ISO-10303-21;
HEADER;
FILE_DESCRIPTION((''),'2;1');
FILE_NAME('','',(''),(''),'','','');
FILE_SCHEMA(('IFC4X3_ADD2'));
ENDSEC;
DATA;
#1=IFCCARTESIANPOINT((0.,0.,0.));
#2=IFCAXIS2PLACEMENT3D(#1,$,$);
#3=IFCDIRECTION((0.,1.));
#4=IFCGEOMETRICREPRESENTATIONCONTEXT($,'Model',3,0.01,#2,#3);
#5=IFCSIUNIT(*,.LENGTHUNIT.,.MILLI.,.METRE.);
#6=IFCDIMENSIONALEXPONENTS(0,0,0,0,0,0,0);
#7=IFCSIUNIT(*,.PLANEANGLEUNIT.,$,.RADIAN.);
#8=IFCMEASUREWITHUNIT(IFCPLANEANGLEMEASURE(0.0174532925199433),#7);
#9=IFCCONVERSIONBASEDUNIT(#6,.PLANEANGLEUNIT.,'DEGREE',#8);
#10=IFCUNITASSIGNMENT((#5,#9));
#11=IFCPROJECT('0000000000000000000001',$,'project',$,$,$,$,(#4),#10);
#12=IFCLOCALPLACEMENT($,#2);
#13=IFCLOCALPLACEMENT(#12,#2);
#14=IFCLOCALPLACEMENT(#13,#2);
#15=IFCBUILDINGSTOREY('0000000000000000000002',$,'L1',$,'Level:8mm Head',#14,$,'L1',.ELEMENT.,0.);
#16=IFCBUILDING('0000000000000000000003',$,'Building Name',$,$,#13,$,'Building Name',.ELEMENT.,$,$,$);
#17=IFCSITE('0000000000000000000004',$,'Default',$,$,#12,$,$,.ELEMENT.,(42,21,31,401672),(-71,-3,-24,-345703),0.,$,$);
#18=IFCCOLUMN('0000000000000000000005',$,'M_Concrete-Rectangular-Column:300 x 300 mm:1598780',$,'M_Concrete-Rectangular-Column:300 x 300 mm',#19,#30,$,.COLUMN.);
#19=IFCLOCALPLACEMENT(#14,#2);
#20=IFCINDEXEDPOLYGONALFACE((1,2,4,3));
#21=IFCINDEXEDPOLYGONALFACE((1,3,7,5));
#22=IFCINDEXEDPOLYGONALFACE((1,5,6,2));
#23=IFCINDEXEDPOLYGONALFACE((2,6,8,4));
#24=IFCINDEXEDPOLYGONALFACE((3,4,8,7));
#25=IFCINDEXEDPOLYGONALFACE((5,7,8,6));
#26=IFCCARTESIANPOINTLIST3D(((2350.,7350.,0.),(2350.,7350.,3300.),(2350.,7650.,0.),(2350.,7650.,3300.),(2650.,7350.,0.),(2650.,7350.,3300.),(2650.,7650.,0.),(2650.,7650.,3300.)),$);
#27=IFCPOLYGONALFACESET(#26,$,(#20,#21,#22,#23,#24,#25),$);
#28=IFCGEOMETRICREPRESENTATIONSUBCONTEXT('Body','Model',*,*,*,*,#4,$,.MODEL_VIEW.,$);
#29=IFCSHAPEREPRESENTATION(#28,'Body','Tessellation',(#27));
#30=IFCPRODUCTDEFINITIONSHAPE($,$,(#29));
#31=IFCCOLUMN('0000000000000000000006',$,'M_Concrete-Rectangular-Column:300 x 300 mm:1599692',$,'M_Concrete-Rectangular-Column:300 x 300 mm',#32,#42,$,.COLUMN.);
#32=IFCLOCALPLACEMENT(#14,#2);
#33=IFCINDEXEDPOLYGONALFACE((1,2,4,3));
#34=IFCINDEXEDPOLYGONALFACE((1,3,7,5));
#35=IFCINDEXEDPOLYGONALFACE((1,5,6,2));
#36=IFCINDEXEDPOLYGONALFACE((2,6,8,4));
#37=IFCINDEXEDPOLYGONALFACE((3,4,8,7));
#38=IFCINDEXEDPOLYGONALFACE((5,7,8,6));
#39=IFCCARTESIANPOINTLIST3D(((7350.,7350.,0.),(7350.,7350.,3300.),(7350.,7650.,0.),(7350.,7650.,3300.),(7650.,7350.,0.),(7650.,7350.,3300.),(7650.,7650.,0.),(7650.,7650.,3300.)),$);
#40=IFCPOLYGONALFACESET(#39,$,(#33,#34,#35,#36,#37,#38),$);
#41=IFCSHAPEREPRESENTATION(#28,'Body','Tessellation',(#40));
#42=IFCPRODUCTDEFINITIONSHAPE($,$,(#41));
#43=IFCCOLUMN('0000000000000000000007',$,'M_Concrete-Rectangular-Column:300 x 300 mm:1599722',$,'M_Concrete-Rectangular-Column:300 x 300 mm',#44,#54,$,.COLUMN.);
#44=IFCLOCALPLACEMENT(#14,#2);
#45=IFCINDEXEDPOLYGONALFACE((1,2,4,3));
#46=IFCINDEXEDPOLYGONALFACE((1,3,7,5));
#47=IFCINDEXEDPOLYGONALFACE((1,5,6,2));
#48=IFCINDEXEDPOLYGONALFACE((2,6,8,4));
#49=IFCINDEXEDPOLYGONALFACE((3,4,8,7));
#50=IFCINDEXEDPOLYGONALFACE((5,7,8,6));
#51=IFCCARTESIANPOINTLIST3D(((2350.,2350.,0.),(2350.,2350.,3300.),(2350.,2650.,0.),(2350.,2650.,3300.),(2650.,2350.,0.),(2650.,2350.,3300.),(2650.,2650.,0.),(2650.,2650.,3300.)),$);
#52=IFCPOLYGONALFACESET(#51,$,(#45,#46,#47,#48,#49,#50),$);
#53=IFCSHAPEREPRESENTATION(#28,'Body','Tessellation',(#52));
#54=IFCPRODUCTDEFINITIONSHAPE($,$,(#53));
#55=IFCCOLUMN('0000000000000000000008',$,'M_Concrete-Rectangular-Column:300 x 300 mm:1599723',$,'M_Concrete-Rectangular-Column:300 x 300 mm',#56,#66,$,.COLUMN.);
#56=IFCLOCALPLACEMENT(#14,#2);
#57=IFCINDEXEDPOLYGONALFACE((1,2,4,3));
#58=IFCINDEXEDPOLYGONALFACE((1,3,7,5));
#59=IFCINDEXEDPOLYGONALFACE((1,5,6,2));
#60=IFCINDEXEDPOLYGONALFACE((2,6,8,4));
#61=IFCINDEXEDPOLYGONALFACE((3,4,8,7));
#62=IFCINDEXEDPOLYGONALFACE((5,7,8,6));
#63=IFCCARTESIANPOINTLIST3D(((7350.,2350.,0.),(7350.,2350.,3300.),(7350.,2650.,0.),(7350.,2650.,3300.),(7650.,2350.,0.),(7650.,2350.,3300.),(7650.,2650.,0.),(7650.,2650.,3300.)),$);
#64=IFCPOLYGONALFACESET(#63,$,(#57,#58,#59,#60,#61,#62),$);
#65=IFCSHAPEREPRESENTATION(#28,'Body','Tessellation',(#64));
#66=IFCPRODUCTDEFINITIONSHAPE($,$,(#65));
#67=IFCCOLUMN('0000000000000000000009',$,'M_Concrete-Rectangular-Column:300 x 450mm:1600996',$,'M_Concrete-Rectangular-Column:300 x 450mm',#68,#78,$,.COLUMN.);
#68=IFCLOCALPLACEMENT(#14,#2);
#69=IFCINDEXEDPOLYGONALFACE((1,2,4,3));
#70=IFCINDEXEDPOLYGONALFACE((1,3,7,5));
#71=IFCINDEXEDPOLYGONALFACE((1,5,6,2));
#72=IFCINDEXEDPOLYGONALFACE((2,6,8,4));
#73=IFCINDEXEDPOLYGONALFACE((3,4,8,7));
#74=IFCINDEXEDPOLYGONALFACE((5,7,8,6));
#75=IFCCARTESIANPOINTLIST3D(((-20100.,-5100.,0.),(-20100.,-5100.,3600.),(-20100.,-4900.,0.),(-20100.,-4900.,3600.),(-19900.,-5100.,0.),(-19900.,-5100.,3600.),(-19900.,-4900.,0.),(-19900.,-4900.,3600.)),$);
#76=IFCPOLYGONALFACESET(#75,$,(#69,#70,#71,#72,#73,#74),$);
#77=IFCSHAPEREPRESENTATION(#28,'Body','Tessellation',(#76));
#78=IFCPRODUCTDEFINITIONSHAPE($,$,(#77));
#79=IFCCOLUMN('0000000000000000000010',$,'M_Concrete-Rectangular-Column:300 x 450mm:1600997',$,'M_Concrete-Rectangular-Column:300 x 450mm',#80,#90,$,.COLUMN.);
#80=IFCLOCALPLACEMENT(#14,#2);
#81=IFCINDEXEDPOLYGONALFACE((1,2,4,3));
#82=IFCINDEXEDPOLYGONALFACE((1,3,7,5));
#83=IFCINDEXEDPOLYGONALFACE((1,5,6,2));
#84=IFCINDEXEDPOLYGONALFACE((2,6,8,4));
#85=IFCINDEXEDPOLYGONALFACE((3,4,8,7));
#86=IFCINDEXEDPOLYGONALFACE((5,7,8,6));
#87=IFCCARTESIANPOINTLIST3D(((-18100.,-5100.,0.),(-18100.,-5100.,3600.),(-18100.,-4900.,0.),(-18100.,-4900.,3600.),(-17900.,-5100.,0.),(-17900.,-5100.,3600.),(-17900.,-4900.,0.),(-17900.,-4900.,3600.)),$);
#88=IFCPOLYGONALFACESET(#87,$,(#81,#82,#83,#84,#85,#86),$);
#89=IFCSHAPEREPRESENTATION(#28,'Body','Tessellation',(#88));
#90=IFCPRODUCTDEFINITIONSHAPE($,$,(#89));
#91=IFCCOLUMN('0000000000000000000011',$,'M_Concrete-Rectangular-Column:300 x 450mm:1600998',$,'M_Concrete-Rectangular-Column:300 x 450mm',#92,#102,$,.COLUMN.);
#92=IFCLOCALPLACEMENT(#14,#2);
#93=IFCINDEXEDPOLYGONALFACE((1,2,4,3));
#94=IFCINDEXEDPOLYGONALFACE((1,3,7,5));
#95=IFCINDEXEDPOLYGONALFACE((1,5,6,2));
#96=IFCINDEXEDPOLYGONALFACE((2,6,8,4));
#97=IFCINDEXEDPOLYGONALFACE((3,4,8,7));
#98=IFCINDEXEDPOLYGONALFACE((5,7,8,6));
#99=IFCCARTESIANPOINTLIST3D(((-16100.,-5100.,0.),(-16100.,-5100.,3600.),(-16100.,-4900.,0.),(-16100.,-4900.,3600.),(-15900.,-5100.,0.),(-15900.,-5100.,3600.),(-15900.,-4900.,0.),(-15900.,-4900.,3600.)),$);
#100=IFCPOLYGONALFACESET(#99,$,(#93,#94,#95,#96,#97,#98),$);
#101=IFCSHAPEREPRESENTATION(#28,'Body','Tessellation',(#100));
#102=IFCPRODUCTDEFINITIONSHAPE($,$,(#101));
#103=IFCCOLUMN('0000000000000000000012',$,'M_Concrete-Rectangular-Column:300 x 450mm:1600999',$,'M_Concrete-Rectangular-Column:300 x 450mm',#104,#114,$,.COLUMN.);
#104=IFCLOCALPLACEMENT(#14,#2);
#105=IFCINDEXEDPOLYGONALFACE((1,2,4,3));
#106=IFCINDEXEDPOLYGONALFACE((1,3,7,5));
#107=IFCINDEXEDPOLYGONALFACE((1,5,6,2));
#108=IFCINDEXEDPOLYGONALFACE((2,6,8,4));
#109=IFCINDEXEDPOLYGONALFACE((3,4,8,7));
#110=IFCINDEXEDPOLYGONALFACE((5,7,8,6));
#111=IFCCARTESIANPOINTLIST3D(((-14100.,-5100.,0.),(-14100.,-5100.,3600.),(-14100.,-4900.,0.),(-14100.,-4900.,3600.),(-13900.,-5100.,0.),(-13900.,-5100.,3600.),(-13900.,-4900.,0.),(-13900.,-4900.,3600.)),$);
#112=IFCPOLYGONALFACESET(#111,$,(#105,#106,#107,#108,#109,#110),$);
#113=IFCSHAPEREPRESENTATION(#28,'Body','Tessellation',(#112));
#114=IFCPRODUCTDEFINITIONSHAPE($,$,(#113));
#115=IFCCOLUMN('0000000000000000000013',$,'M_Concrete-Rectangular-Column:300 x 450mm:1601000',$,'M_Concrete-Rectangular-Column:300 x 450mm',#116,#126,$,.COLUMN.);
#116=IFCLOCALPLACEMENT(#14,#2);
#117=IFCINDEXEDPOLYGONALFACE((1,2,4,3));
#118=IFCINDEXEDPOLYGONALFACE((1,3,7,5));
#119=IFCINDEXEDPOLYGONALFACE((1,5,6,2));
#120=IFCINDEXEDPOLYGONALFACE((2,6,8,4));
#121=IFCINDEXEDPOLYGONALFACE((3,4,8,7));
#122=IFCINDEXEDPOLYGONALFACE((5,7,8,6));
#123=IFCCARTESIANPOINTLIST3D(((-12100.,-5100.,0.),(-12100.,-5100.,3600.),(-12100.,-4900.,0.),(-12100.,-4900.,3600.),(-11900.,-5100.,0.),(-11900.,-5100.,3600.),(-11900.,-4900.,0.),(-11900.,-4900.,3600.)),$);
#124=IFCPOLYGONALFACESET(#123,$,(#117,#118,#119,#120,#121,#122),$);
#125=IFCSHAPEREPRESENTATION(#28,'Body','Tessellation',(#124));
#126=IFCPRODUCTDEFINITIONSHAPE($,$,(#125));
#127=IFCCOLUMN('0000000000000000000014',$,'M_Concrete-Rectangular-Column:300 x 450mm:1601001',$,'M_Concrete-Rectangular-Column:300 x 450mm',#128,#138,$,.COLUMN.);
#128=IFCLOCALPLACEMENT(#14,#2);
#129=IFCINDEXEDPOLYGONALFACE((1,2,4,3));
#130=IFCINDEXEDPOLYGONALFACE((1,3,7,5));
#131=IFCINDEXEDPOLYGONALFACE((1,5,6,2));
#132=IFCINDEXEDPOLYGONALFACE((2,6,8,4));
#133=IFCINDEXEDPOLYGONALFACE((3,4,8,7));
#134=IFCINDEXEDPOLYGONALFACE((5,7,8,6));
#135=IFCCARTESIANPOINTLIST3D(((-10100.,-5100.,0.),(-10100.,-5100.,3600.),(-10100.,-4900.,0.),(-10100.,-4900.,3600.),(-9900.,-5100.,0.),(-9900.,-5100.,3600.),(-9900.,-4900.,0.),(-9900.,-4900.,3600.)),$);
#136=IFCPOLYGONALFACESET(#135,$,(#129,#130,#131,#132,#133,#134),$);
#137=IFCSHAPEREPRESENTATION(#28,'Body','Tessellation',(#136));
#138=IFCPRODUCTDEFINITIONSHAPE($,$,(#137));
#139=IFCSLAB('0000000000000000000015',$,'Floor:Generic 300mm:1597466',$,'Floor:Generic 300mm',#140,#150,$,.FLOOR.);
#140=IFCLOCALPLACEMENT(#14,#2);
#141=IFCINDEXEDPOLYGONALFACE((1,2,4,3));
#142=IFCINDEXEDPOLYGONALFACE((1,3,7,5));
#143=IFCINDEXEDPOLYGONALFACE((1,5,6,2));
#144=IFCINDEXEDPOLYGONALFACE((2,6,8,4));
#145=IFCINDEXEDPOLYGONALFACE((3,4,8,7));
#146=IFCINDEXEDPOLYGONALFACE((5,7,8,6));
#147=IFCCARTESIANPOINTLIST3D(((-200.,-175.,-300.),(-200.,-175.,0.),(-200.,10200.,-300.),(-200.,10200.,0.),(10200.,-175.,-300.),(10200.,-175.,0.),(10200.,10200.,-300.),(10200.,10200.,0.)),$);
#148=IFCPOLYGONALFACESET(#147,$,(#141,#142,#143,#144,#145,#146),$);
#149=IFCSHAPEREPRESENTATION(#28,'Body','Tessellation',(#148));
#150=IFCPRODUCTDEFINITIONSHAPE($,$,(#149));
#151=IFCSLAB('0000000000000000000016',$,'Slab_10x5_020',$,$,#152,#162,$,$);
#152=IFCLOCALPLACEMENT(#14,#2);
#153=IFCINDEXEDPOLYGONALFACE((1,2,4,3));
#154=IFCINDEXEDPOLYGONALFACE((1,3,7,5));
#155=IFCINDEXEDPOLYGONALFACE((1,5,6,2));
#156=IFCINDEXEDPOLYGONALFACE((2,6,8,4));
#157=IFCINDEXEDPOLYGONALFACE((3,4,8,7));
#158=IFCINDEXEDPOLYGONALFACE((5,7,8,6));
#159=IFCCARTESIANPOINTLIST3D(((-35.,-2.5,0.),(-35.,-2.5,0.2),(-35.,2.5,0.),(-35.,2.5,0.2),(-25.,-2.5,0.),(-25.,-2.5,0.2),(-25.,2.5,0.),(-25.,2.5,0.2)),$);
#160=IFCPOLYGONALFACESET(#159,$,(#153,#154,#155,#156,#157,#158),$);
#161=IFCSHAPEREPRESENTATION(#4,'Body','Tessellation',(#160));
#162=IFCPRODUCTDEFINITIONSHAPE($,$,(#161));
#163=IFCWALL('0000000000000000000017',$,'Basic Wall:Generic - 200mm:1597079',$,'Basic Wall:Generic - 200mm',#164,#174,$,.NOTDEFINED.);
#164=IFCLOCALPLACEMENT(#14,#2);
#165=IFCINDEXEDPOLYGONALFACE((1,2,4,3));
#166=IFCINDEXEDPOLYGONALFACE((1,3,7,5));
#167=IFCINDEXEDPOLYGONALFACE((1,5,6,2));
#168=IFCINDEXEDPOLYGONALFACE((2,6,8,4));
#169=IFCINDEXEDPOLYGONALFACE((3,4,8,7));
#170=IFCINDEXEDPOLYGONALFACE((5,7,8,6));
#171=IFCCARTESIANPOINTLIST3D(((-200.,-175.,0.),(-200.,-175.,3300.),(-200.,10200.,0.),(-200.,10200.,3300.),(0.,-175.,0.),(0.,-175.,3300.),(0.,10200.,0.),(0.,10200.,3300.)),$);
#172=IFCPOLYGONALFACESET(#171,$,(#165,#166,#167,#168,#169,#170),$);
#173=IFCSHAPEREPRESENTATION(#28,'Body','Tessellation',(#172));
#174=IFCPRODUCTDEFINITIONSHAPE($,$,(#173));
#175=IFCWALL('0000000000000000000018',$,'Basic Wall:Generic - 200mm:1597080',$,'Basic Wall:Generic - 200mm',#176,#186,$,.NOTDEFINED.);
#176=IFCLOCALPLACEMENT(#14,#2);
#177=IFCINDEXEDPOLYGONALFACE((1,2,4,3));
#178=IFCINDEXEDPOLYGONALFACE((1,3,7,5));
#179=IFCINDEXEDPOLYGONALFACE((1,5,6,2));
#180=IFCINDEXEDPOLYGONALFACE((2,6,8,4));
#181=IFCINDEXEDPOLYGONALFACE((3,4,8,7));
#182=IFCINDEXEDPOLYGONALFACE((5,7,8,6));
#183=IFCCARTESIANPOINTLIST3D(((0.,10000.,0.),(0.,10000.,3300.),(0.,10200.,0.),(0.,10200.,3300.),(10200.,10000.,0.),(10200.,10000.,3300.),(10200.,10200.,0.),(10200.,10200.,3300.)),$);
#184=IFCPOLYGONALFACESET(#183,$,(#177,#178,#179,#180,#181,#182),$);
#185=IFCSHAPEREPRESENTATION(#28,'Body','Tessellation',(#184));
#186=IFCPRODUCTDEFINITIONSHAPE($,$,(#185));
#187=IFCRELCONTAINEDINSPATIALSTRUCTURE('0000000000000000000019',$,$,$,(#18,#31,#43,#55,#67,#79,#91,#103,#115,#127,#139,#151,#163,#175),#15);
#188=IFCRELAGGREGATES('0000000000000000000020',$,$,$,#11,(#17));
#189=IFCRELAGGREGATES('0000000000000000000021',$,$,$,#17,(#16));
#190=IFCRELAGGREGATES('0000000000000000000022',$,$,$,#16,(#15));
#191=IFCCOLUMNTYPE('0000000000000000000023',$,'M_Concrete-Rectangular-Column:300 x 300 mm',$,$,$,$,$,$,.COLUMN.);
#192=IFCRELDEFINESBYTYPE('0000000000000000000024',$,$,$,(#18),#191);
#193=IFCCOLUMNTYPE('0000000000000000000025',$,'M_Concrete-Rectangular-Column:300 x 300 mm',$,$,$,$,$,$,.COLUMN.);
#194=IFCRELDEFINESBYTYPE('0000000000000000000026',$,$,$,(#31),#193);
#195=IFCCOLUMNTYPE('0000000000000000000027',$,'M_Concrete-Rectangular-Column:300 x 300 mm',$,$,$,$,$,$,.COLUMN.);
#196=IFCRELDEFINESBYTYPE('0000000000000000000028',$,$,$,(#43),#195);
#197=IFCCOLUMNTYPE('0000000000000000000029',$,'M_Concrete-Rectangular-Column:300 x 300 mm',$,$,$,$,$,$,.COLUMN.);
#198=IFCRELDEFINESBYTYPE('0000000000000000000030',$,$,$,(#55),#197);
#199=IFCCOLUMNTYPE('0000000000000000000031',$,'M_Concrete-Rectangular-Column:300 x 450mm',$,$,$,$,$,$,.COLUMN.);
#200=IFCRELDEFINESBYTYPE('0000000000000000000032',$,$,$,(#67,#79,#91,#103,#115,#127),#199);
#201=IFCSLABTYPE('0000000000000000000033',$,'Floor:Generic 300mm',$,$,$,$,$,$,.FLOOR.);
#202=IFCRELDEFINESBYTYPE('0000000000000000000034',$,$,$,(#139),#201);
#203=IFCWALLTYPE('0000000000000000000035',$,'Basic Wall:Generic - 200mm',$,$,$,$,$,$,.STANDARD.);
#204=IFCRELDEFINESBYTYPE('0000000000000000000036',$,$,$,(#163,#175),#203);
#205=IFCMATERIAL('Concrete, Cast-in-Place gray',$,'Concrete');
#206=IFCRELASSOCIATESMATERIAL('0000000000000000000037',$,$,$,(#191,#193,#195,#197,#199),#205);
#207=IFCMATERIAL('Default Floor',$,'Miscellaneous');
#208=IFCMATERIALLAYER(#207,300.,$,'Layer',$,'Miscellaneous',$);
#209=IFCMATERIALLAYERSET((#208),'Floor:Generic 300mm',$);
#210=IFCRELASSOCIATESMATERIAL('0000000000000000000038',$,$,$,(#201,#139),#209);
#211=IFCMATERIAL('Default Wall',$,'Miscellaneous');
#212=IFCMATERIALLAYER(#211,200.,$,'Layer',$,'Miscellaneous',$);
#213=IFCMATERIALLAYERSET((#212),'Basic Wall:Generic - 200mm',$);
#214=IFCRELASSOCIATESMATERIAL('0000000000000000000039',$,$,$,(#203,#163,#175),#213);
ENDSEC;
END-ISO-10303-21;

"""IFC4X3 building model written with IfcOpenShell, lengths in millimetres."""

from ifc_helpers import new_model, entity, si_unit, converted_unit, direction, frame, frame_2d, origin, origin_2d, origin_2d_with_axis, place, context, subcontext, project, spatial, rectangle, extrude, source, transform, mapped, material, layer, layer_set, layer_usage, material_profile, profile_set, type_object, type_shapes, element, save


model = new_model("IFC4X3")

# Units and contexts
model_context = context("Model", 3, precision=0.01, world=origin(), true_north=direction((0.0, 1.0)))
body_context = subcontext(model_context, "Body", "Model", "MODEL_VIEW")
ifc_project = project(units=[si_unit("LENGTHUNIT", "METRE", prefix="MILLI"), converted_unit("PLANEANGLEUNIT", "DEGREE", entity("IfcPlaneAngleMeasure", 0.0174532925199433), si_unit("PLANEANGLEUNIT", "RADIAN"), dimensions=[0, 0, 0, 0, 0, 0, 0])], contexts=[model_context])

# Site, building, storey
site_placement = place(None, origin())
site = spatial("IfcSite", under=ifc_project, at=site_placement, Name="Default", CompositionType="ELEMENT", RefLatitude=(42, 21, 31, 401672), RefLongitude=(-71, -3, -24, -345703), RefElevation=0.0)
building_placement = place(site_placement, origin())
building = spatial("IfcBuilding", under=site, at=building_placement, Name="Building Name", LongName="Building Name", CompositionType="ELEMENT")
storey_placement = place(building_placement, origin())
storey = spatial("IfcBuildingStorey", under=building, at=storey_placement, Name="L1", ObjectType="Level:8mm Head", LongName="L1", CompositionType="ELEMENT", Elevation=0.0)

# Columns
ifc_material_1 = material(Name="Concrete, Cast-in-Place gray", Category="Concrete")
ifc_material_profile_1 = material_profile(ifc_material_1, rectangle(XDim=300.0, YDim=300.0, at=origin_2d_with_axis()), Name="300 x 300 mm")
ifc_profile_set_1 = profile_set([ifc_material_profile_1], Name="300 x 300 mm")
column_type_1 = type_object("IfcColumnType", Name="M_Concrete-Rectangular-Column:300 x 300 mm", PredefinedType="COLUMN", material=ifc_profile_set_1)
shared_shape_1 = source(origin(), body_context, "Body", "SweptSolid", [
    extrude(rectangle(XDim=300.0, YDim=300.0, at=origin_2d_with_axis()), frame((2500.0, 7500.0, 0.0)), (0.0, 0.0, 1.0), 3300.0),
])
type_shapes(column_type_1, [shared_shape_1])
column_1_placement = place(storey_placement, origin())
element("IfcColumn", 1, at=column_1_placement, inside=storey, type_object=column_type_1, Name="M_Concrete-Rectangular-Column:300 x 300 mm:1598780", ObjectType="M_Concrete-Rectangular-Column:300 x 300 mm", PredefinedType="COLUMN", context=body_context, shape_type="MappedRepresentation", body=[
    mapped(shared_shape_1, transform((0.0, 0.0, 0.0), scale=1.0)),
])
column_type_2 = type_object("IfcColumnType", Name="M_Concrete-Rectangular-Column:300 x 300 mm", PredefinedType="COLUMN", material=ifc_profile_set_1)
shared_shape_2 = source(origin(), body_context, "Body", "SweptSolid", [
    extrude(rectangle(XDim=300.0, YDim=300.0, at=origin_2d_with_axis()), frame((7500.0, 7500.0, 0.0)), (0.0, 0.0, 1.0), 3300.0),
])
type_shapes(column_type_2, [shared_shape_2])
column_2_placement = place(storey_placement, origin())
element("IfcColumn", 2, at=column_2_placement, inside=storey, type_object=column_type_2, Name="M_Concrete-Rectangular-Column:300 x 300 mm:1599692", ObjectType="M_Concrete-Rectangular-Column:300 x 300 mm", PredefinedType="COLUMN", context=body_context, shape_type="MappedRepresentation", body=[
    mapped(shared_shape_2, transform((0.0, 0.0, 0.0), scale=1.0)),
])
column_type_3 = type_object("IfcColumnType", Name="M_Concrete-Rectangular-Column:300 x 300 mm", PredefinedType="COLUMN", material=ifc_profile_set_1)
shared_shape_3 = source(origin(), body_context, "Body", "SweptSolid", [
    extrude(rectangle(XDim=300.0, YDim=300.0, at=origin_2d_with_axis()), frame((2500.0, 2500.0, 0.0)), (0.0, 0.0, 1.0), 3300.0),
])
type_shapes(column_type_3, [shared_shape_3])
column_3_placement = place(storey_placement, origin())
element("IfcColumn", 3, at=column_3_placement, inside=storey, type_object=column_type_3, Name="M_Concrete-Rectangular-Column:300 x 300 mm:1599722", ObjectType="M_Concrete-Rectangular-Column:300 x 300 mm", PredefinedType="COLUMN", context=body_context, shape_type="MappedRepresentation", body=[
    mapped(shared_shape_3, transform((0.0, 0.0, 0.0), scale=1.0)),
])
column_type_4 = type_object("IfcColumnType", Name="M_Concrete-Rectangular-Column:300 x 300 mm", PredefinedType="COLUMN", material=ifc_profile_set_1)
shared_shape_4 = source(origin(), body_context, "Body", "SweptSolid", [
    extrude(rectangle(XDim=300.0, YDim=300.0, at=origin_2d_with_axis()), frame((7500.0, 2500.0, 0.0)), (0.0, 0.0, 1.0), 3300.0),
])
type_shapes(column_type_4, [shared_shape_4])
column_4_placement = place(storey_placement, origin())
element("IfcColumn", 4, at=column_4_placement, inside=storey, type_object=column_type_4, Name="M_Concrete-Rectangular-Column:300 x 300 mm:1599723", ObjectType="M_Concrete-Rectangular-Column:300 x 300 mm", PredefinedType="COLUMN", context=body_context, shape_type="MappedRepresentation", body=[
    mapped(shared_shape_4, transform((0.0, 0.0, 0.0), scale=1.0)),
])
ifc_material_profile_2 = material_profile(ifc_material_1, rectangle(XDim=200.0, YDim=200.0, at=origin_2d_with_axis()), Name="300 x 450mm")
ifc_profile_set_2 = profile_set([ifc_material_profile_2], Name="300 x 450mm")
column_type_5 = type_object("IfcColumnType", Name="M_Concrete-Rectangular-Column:300 x 450mm", PredefinedType="COLUMN", material=ifc_profile_set_2)
shared_shape_5 = source(origin(), body_context, "Body", "SweptSolid", [
    extrude(rectangle(XDim=200.0, YDim=200.0, at=origin_2d_with_axis()), frame((0.0, 0.0, 0.0), z_axis=(0.0, 0.0, 1.0), x_axis=(-1.0, 0.0, 0.0)), (0.0, 0.0, 1.0), 3600.0),
])
type_shapes(column_type_5, [shared_shape_5])
for number, where, z_axis, x_axis, name in (
    (5, (-20000.0, -5000.0, 0.0), (0.0, 0.0, 1.0), (0.0, -1.0, 0.0), "M_Concrete-Rectangular-Column:300 x 450mm:1600996"),
    (6, (-18000.0, -5000.0, 0.0), (0.0, 0.0, 1.0), (0.0, -1.0, 0.0), "M_Concrete-Rectangular-Column:300 x 450mm:1600997"),
    (7, (-16000.0, -5000.0, 0.0), (0.0, 0.0, 1.0), (0.0, -1.0, 0.0), "M_Concrete-Rectangular-Column:300 x 450mm:1600998"),
    (8, (-14000.0, -5000.0, 0.0), (0.0, 0.0, 1.0), (0.0, -1.0, 0.0), "M_Concrete-Rectangular-Column:300 x 450mm:1600999"),
    (9, (-12000.0, -5000.0, 0.0), (0.0, 0.0, 1.0), (0.0, -1.0, 0.0), "M_Concrete-Rectangular-Column:300 x 450mm:1601000"),
    (10, (-10000.0, -5000.0, 0.0), (0.0, 0.0, 1.0), (0.0, -1.0, 0.0), "M_Concrete-Rectangular-Column:300 x 450mm:1601001"),
):
    element("IfcColumn", number, at=place(storey_placement, frame(where, z_axis=z_axis, x_axis=x_axis)), inside=storey, type_object=column_type_5, Name=name, ObjectType="M_Concrete-Rectangular-Column:300 x 450mm", PredefinedType="COLUMN", context=body_context, shape_type="MappedRepresentation", body=[
        mapped(shared_shape_5, transform((0.0, 0.0, 0.0), scale=1.0)),
    ])

# Slabs
ifc_material_2 = material(Name="Default Floor", Category="Miscellaneous")
ifc_layer_1 = layer(ifc_material_2, 300.0, Name="Layer", Category="Miscellaneous")
ifc_layer_set_1 = layer_set([ifc_layer_1], Name="Floor:Generic 300mm")
ifc_layer_usage = layer_usage(ifc_layer_set_1, "AXIS3", "POSITIVE", 0.0)
slab_type = type_object("IfcSlabType", Name="Floor:Generic 300mm", PredefinedType="FLOOR", material=ifc_layer_set_1)
slab_1_placement = place(storey_placement, origin())
element("IfcSlab", 11, at=slab_1_placement, inside=storey, type_object=slab_type, material=ifc_layer_usage, Name="Floor:Generic 300mm:1597466", ObjectType="Floor:Generic 300mm", PredefinedType="FLOOR", context=body_context, shape_type="SweptSolid", body=[
    extrude(rectangle(XDim=10375.0, YDim=10400.0, at=origin_2d_with_axis()), frame((5000.0, 5012.5, 0.0), z_axis=(0.0, 0.0, -1.0), x_axis=(0.0, 1.0, 0.0)), (0.0, 0.0, 1.0), 300.0),
])
slab_2_placement = place(None, frame((-30.0, 0.0, 0.0)))
element("IfcSlab", 12, at=slab_2_placement, inside=storey, Name="Slab_10x5_020", context=model_context, shape_type="SweptSolid", body=[
    extrude(rectangle(XDim=10.0, YDim=5.0, at=origin_2d()), origin(), (0.0, 0.0, 1.0), 0.2),
])

# Walls
ifc_material_3 = material(Name="Default Wall", Category="Miscellaneous")
ifc_layer_2 = layer(ifc_material_3, 200.0, Name="Layer", Category="Miscellaneous")
ifc_layer_set_2 = layer_set([ifc_layer_2], Name="Basic Wall:Generic - 200mm")
wall_type_1 = type_object("IfcWallType", Name="Basic Wall:Generic - 200mm", PredefinedType="STANDARD", material=ifc_layer_set_2)
wall_1_placement = place(storey_placement, frame((-100.0, 10200.0, 0.0), z_axis=(0.0, 0.0, 1.0), x_axis=(0.0, -1.0, 0.0)))
element("IfcWall", 13, at=wall_1_placement, inside=storey, type_object=wall_type_1, material=ifc_layer_set_2, Name="Basic Wall:Generic - 200mm:1597079", ObjectType="Basic Wall:Generic - 200mm", PredefinedType="NOTDEFINED", context=body_context, shape_type="SweptSolid", body=[
    extrude(rectangle(XDim=10375.0, YDim=200.0, at=frame_2d((5187.5, 0.0), x_axis=(-1.0, 0.0))), origin(), (0.0, 0.0, 1.0), 3300.0),
])
wall_2_placement = place(storey_placement, frame((10200.0, 10100.0, 0.0), z_axis=(0.0, 0.0, 1.0), x_axis=(-1.0, 0.0, 0.0)))
element("IfcWall", 14, at=wall_2_placement, inside=storey, type_object=wall_type_1, material=ifc_layer_set_2, Name="Basic Wall:Generic - 200mm:1597080", ObjectType="Basic Wall:Generic - 200mm", PredefinedType="NOTDEFINED", context=body_context, shape_type="SweptSolid", body=[
    extrude(rectangle(XDim=10200.0, YDim=200.0, at=frame_2d((5100.0, 0.0), x_axis=(-1.0, 0.0))), origin(), (0.0, 0.0, 1.0), 3300.0),
])

save(model, "model.ifc")
